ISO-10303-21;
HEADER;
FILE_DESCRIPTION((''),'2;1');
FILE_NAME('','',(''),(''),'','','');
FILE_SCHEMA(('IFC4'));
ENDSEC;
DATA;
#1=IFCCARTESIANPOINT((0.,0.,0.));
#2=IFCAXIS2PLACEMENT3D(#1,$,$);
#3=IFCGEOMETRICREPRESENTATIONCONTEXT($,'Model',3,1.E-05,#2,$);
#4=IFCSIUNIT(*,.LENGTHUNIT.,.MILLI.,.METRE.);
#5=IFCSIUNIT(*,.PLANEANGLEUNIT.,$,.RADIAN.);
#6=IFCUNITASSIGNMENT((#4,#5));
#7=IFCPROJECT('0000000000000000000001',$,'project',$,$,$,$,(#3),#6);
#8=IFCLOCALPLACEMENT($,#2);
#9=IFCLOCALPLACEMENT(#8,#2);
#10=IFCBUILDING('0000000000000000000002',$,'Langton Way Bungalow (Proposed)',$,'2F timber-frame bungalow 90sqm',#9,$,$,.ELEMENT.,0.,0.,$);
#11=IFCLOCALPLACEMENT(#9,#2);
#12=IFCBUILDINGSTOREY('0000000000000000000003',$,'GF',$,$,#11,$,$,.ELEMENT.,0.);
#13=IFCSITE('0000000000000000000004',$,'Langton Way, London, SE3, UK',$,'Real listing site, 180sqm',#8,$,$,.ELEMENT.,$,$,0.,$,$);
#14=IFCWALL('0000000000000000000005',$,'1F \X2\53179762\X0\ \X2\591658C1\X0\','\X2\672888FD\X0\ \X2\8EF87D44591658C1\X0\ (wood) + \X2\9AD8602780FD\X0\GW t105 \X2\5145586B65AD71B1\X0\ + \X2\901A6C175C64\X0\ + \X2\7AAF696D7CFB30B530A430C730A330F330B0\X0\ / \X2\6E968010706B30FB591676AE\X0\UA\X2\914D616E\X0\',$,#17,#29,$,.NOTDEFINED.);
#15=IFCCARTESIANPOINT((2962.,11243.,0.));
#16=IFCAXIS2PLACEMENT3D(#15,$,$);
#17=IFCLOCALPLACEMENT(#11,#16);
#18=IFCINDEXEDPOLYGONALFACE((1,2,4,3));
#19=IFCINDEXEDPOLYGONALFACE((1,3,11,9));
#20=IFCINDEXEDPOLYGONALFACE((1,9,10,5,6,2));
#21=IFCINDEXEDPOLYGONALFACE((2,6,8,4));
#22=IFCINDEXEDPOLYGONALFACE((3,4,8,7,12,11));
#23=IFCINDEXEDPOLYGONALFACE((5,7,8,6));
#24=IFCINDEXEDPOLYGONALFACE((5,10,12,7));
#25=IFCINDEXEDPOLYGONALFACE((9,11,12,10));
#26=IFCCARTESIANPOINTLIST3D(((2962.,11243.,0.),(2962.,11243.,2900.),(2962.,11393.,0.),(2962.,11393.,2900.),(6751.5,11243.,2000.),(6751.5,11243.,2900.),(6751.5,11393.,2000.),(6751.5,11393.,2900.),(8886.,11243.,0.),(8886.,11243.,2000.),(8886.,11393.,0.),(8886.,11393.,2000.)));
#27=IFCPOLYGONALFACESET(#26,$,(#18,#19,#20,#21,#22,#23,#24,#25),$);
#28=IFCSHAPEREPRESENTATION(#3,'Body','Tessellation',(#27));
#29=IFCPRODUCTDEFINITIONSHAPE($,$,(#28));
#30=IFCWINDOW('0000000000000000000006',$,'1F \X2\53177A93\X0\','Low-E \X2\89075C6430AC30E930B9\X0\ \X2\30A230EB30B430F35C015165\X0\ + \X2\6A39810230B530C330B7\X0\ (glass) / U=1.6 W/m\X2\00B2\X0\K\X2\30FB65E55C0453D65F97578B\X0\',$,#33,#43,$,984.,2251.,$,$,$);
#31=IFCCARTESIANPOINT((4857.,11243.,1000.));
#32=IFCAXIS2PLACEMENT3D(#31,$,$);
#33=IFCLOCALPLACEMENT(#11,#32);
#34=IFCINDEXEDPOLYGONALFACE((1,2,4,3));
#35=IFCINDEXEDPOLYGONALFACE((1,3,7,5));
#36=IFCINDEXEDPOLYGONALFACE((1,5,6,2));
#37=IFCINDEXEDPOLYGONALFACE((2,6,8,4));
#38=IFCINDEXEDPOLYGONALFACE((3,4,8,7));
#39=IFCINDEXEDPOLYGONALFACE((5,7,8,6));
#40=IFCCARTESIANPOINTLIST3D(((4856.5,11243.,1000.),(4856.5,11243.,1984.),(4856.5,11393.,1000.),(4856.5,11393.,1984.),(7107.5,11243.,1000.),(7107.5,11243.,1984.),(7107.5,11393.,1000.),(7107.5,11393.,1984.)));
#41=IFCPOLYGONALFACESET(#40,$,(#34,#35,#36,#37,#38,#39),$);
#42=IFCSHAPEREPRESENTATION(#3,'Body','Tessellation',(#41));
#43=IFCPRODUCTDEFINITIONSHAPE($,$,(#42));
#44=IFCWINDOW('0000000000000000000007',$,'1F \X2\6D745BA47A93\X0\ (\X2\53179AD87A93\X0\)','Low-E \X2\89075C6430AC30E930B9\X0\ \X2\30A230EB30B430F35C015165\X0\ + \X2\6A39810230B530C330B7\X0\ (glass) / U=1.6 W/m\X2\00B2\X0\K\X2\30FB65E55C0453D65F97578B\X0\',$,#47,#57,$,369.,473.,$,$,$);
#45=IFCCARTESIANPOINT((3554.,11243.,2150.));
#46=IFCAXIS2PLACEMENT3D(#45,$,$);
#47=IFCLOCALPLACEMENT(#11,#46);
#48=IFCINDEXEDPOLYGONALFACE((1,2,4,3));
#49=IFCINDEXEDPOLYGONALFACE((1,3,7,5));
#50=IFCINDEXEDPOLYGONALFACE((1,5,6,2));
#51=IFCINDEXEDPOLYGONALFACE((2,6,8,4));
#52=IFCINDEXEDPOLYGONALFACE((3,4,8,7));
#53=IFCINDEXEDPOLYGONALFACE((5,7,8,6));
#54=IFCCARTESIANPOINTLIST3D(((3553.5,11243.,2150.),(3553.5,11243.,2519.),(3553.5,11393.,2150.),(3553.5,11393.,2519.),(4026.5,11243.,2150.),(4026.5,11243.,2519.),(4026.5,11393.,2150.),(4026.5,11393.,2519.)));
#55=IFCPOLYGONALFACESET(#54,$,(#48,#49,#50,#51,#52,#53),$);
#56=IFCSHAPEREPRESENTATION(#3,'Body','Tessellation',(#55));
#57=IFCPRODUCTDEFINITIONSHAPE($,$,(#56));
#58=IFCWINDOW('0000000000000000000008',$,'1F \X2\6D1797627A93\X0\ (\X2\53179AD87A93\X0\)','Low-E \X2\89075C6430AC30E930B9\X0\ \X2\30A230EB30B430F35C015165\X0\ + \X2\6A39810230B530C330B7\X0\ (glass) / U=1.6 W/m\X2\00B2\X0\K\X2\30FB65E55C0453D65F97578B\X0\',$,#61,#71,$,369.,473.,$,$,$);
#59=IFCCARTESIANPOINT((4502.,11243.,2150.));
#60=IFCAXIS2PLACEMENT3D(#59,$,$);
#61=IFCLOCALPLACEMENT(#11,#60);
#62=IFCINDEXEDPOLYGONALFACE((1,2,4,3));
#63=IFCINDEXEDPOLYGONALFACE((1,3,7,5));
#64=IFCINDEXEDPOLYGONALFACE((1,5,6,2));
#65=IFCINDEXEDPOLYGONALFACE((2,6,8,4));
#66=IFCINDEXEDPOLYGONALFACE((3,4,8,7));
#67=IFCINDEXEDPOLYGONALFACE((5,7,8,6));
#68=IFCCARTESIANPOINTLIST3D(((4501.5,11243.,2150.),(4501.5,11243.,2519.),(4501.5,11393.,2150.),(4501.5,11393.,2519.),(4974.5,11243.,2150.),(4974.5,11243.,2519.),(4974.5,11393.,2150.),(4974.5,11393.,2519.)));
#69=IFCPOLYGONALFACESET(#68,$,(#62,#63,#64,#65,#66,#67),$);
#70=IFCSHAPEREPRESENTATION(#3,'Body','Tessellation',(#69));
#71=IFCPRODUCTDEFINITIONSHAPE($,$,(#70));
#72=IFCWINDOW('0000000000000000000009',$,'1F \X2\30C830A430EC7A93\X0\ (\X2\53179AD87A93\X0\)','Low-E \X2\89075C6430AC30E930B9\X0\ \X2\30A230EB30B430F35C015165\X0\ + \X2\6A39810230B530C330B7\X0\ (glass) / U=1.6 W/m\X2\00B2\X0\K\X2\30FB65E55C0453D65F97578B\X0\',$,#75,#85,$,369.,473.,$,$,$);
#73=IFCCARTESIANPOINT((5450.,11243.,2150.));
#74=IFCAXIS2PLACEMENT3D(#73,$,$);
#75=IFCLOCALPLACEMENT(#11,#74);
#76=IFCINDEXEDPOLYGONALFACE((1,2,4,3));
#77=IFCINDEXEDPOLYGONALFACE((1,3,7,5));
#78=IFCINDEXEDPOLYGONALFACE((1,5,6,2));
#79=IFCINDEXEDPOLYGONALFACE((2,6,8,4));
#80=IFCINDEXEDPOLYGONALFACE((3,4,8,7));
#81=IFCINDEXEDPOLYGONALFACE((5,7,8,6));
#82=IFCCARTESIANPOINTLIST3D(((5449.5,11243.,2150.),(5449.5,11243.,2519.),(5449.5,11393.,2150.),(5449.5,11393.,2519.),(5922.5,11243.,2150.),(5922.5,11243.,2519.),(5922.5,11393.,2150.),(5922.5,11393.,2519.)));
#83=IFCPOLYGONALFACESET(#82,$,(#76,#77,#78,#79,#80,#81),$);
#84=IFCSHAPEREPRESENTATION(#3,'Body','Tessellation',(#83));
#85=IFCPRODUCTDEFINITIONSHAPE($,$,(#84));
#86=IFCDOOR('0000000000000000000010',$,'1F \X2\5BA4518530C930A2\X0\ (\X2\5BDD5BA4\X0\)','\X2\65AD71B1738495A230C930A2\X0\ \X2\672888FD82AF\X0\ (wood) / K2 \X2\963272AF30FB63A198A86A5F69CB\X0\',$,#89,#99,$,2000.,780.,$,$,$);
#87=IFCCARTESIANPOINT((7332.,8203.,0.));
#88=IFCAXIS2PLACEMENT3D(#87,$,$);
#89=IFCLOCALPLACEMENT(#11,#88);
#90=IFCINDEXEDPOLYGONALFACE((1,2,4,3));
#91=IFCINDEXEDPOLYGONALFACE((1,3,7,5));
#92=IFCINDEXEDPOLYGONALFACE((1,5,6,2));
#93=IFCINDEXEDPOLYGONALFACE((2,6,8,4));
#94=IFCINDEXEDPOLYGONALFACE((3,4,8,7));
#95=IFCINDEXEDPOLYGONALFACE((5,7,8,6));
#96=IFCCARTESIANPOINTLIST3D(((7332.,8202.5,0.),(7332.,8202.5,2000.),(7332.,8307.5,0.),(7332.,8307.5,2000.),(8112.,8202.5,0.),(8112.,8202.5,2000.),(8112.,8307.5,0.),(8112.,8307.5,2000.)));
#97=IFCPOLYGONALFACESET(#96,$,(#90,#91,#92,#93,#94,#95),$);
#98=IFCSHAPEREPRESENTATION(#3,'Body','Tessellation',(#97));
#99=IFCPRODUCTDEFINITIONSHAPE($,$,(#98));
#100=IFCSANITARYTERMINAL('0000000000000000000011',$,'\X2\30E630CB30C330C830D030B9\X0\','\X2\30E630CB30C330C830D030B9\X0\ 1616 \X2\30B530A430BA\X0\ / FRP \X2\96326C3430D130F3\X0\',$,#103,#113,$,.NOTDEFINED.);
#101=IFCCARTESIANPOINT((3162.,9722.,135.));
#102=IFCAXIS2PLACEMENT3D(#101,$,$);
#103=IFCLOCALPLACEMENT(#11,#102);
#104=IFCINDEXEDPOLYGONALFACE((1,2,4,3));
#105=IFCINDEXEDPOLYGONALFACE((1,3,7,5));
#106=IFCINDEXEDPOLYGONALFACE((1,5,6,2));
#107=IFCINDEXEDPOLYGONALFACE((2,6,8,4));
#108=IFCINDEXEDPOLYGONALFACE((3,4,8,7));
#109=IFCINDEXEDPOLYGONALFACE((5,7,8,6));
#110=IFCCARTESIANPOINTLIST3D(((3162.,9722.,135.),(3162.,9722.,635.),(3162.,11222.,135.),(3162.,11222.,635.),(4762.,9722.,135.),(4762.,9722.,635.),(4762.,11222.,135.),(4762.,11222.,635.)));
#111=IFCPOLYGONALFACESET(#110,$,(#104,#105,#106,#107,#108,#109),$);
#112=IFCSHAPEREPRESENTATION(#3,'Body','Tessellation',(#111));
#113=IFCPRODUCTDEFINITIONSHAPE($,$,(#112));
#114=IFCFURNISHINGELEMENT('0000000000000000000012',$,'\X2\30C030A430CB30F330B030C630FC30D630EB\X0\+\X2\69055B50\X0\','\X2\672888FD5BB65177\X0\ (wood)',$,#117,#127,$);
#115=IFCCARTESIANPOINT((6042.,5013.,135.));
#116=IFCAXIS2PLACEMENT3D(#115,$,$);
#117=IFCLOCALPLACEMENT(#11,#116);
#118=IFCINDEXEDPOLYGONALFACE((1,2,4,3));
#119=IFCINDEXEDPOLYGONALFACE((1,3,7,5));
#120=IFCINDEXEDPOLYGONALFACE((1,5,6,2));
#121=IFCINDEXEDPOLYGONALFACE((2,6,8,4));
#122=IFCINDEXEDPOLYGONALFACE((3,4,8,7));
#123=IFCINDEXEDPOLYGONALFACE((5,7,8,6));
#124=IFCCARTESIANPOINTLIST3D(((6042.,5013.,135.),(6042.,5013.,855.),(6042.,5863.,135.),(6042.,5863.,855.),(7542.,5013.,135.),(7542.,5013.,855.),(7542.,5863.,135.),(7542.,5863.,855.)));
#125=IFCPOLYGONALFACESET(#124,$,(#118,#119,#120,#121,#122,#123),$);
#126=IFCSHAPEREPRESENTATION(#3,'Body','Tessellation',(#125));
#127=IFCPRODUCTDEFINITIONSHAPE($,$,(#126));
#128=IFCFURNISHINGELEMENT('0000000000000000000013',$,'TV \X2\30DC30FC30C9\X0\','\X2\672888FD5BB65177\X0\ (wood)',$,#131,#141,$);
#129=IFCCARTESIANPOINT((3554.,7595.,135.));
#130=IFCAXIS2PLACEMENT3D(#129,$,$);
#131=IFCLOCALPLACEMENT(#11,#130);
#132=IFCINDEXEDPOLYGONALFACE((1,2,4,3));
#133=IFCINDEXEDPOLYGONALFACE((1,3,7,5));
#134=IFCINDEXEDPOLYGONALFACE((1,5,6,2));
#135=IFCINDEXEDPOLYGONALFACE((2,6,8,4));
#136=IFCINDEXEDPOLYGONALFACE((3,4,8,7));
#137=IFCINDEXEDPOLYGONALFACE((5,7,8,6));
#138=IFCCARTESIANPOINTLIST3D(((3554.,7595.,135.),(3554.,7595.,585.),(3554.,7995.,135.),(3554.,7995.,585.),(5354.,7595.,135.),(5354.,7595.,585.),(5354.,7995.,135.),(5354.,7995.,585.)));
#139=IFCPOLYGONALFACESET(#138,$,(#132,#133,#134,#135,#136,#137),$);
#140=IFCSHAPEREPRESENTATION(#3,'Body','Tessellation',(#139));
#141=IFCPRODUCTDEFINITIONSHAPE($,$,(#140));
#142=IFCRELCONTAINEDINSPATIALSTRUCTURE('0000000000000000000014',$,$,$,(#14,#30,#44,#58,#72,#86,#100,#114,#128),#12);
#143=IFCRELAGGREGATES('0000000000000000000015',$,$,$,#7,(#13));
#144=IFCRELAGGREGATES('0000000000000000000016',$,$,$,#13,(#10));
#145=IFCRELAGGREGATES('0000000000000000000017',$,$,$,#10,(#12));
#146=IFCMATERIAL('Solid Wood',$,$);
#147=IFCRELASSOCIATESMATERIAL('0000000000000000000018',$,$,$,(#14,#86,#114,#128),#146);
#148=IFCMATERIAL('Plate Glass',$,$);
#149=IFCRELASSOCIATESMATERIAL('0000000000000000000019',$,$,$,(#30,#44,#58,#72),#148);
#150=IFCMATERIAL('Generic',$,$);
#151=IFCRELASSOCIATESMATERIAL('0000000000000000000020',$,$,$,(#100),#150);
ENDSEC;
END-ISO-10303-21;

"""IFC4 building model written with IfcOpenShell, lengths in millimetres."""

from ifc_helpers import new_model, si_unit, frame, frame_2d, origin, place, context, project, spatial, rectangle, extrude, material, element, fill, save


model = new_model("IFC4")

# Units and contexts
model_context = context("Model", 3, precision=1e-05, world=origin())
ifc_project = project(units=[si_unit("LENGTHUNIT", "METRE", prefix="MILLI"), si_unit("PLANEANGLEUNIT", "RADIAN")], contexts=[model_context])

# Site, building, storey
site_placement = place(None, origin())
site = spatial("IfcSite", under=ifc_project, at=site_placement, Name="Langton Way, London, SE3, UK", ObjectType="Real listing site, 180sqm", CompositionType="ELEMENT", RefElevation=0.0)
building_placement = place(site_placement, origin())
building = spatial("IfcBuilding", under=site, at=building_placement, Name="Langton Way Bungalow (Proposed)", ObjectType="2F timber-frame bungalow 90sqm", CompositionType="ELEMENT", ElevationOfRefHeight=0.0, ElevationOfTerrain=0.0)
storey_placement = place(building_placement, origin())
storey = spatial("IfcBuildingStorey", under=building, at=storey_placement, Name="GF", CompositionType="ELEMENT", Elevation=0.0)

# Wall, openings, windows
ifc_material_1 = material(Name="Solid Wood")
wall_1_placement = place(storey_placement, frame((2962.0, 11243.0, 0.0)))
wall_1 = element("IfcWall", 1, at=wall_1_placement, inside=storey, material=ifc_material_1, Name="1F 北面 外壁", Description="木製 軸組外壁 (wood) + 高性能GW t105 充填断熱 + 通気層 + 窯業系サイディング / 準耐火・外皮UA配慮", PredefinedType="NOTDEFINED", context=model_context, shape_type="SweptSolid", body=[
    extrude(rectangle(XDim=5924.0, YDim=150.0, at=frame_2d((2962.0, 75.0))), frame((2962.0, 11243.0, 0.0)), (0.0, 0.0, 1.0), 2900.0),
])
opening_1_placement = place(storey_placement, frame((4857.0, 11243.0, 1000.0)))
opening_1 = element("IfcOpeningElement", 2, at=opening_1_placement, cuts=wall_1, PredefinedType="NOTDEFINED", context=model_context, shape_type="SweptSolid", body=[
    extrude(rectangle(XDim=2251.0, YDim=150.0, at=frame_2d((1125.0, 75.0))), frame((4857.0, 11243.0, 1000.0)), (0.0, 0.0, 1.0), 984.0),
])
opening_2_placement = place(storey_placement, frame((3554.0, 11243.0, 2150.0)))
opening_2 = element("IfcOpeningElement", 3, at=opening_2_placement, cuts=wall_1, PredefinedType="NOTDEFINED", context=model_context, shape_type="SweptSolid", body=[
    extrude(rectangle(XDim=473.0, YDim=150.0, at=frame_2d((236.0, 75.0))), frame((3554.0, 11243.0, 2150.0)), (0.0, 0.0, 1.0), 369.0),
])
opening_3_placement = place(storey_placement, frame((4502.0, 11243.0, 2150.0)))
opening_3 = element("IfcOpeningElement", 4, at=opening_3_placement, cuts=wall_1, PredefinedType="NOTDEFINED", context=model_context, shape_type="SweptSolid", body=[
    extrude(rectangle(XDim=473.0, YDim=150.0, at=frame_2d((236.0, 75.0))), frame((4502.0, 11243.0, 2150.0)), (0.0, 0.0, 1.0), 369.0),
])
opening_4_placement = place(storey_placement, frame((5450.0, 11243.0, 2150.0)))
opening_4 = element("IfcOpeningElement", 5, at=opening_4_placement, cuts=wall_1, PredefinedType="NOTDEFINED", context=model_context, shape_type="SweptSolid", body=[
    extrude(rectangle(XDim=473.0, YDim=150.0, at=frame_2d((236.0, 75.0))), frame((5450.0, 11243.0, 2150.0)), (0.0, 0.0, 1.0), 369.0),
])
ifc_material_2 = material(Name="Plate Glass")
window_1_placement = place(storey_placement, frame((4857.0, 11243.0, 1000.0)))
window_1 = element("IfcWindow", 6, at=window_1_placement, inside=storey, material=ifc_material_2, Name="1F 北窓", Description="Low-E 複層ガラス アルゴン封入 + 樹脂サッシ (glass) / U=1.6 W/m²K・日射取得型", OverallHeight=984.0, OverallWidth=2251.0, context=model_context, shape_type="SweptSolid", body=[
    extrude(rectangle(XDim=2251.0, YDim=150.0, at=frame_2d((1125.0, 75.0))), frame((4857.0, 11243.0, 1000.0)), (0.0, 0.0, 1.0), 984.0),
])
fill(opening_1, window_1)
window_2_placement = place(storey_placement, frame((3554.0, 11243.0, 2150.0)))
window_2 = element("IfcWindow", 7, at=window_2_placement, inside=storey, material=ifc_material_2, Name="1F 浴室窓 (北高窓)", Description="Low-E 複層ガラス アルゴン封入 + 樹脂サッシ (glass) / U=1.6 W/m²K・日射取得型", OverallHeight=369.0, OverallWidth=473.0, context=model_context, shape_type="SweptSolid", body=[
    extrude(rectangle(XDim=473.0, YDim=150.0, at=frame_2d((236.0, 75.0))), frame((3554.0, 11243.0, 2150.0)), (0.0, 0.0, 1.0), 369.0),
])
fill(opening_2, window_2)
window_3_placement = place(storey_placement, frame((4502.0, 11243.0, 2150.0)))
window_3 = element("IfcWindow", 8, at=window_3_placement, inside=storey, material=ifc_material_2, Name="1F 洗面窓 (北高窓)", Description="Low-E 複層ガラス アルゴン封入 + 樹脂サッシ (glass) / U=1.6 W/m²K・日射取得型", OverallHeight=369.0, OverallWidth=473.0, context=model_context, shape_type="SweptSolid", body=[
    extrude(rectangle(XDim=473.0, YDim=150.0, at=frame_2d((236.0, 75.0))), frame((4502.0, 11243.0, 2150.0)), (0.0, 0.0, 1.0), 369.0),
])
fill(opening_3, window_3)
window_4_placement = place(storey_placement, frame((5450.0, 11243.0, 2150.0)))
window_4 = element("IfcWindow", 9, at=window_4_placement, inside=storey, material=ifc_material_2, Name="1F トイレ窓 (北高窓)", Description="Low-E 複層ガラス アルゴン封入 + 樹脂サッシ (glass) / U=1.6 W/m²K・日射取得型", OverallHeight=369.0, OverallWidth=473.0, context=model_context, shape_type="SweptSolid", body=[
    extrude(rectangle(XDim=473.0, YDim=150.0, at=frame_2d((236.0, 75.0))), frame((5450.0, 11243.0, 2150.0)), (0.0, 0.0, 1.0), 369.0),
])
fill(opening_4, window_4)

# Door
door_1_placement = place(storey_placement, frame((7332.0, 8203.0, 0.0)))
element("IfcDoor", 10, at=door_1_placement, inside=storey, material=ifc_material_1, Name="1F 室内ドア (寝室)", Description="断熱玄関ドア 木製芯 (wood) / K2 防犯・採風機構", OverallHeight=2000.0, OverallWidth=780.0, context=model_context, shape_type="SweptSolid", body=[
    extrude(rectangle(XDim=780.0, YDim=105.0, at=frame_2d((390.0, 52.0))), frame((7332.0, 8203.0, 0.0)), (0.0, 0.0, 1.0), 2000.0),
])

# Sanitary terminal
ifc_material_3 = material(Name="Generic")
sanitary_terminal_placement = place(storey_placement, frame((3162.0, 9722.0, 135.0)))
element("IfcSanitaryTerminal", 11, at=sanitary_terminal_placement, inside=storey, material=ifc_material_3, Name="ユニットバス", Description="ユニットバス 1616 サイズ / FRP 防水パン", PredefinedType="NOTDEFINED", context=model_context, shape_type="SweptSolid", body=[
    extrude(rectangle(XDim=1600.0, YDim=1500.0, at=frame_2d((800.0, 750.0))), frame((3162.0, 9722.0, 135.0)), (0.0, 0.0, 1.0), 500.0),
])

# Furnishing elements
furnishing_1_placement = place(storey_placement, frame((6042.0, 5013.0, 135.0)))
element("IfcFurnishingElement", 12, at=furnishing_1_placement, inside=storey, material=ifc_material_1, Name="ダイニングテーブル+椅子", Description="木製家具 (wood)", context=model_context, shape_type="SweptSolid", body=[
    extrude(rectangle(XDim=1500.0, YDim=850.0, at=frame_2d((750.0, 425.0))), frame((6042.0, 5013.0, 135.0)), (0.0, 0.0, 1.0), 720.0),
])
furnishing_2_placement = place(storey_placement, frame((3554.0, 7595.0, 135.0)))
element("IfcFurnishingElement", 13, at=furnishing_2_placement, inside=storey, material=ifc_material_1, Name="TV ボード", Description="木製家具 (wood)", context=model_context, shape_type="SweptSolid", body=[
    extrude(rectangle(XDim=1800.0, YDim=400.0, at=frame_2d((900.0, 200.0))), frame((3554.0, 7595.0, 135.0)), (0.0, 0.0, 1.0), 450.0),
])

save(model, "model.ifc")
